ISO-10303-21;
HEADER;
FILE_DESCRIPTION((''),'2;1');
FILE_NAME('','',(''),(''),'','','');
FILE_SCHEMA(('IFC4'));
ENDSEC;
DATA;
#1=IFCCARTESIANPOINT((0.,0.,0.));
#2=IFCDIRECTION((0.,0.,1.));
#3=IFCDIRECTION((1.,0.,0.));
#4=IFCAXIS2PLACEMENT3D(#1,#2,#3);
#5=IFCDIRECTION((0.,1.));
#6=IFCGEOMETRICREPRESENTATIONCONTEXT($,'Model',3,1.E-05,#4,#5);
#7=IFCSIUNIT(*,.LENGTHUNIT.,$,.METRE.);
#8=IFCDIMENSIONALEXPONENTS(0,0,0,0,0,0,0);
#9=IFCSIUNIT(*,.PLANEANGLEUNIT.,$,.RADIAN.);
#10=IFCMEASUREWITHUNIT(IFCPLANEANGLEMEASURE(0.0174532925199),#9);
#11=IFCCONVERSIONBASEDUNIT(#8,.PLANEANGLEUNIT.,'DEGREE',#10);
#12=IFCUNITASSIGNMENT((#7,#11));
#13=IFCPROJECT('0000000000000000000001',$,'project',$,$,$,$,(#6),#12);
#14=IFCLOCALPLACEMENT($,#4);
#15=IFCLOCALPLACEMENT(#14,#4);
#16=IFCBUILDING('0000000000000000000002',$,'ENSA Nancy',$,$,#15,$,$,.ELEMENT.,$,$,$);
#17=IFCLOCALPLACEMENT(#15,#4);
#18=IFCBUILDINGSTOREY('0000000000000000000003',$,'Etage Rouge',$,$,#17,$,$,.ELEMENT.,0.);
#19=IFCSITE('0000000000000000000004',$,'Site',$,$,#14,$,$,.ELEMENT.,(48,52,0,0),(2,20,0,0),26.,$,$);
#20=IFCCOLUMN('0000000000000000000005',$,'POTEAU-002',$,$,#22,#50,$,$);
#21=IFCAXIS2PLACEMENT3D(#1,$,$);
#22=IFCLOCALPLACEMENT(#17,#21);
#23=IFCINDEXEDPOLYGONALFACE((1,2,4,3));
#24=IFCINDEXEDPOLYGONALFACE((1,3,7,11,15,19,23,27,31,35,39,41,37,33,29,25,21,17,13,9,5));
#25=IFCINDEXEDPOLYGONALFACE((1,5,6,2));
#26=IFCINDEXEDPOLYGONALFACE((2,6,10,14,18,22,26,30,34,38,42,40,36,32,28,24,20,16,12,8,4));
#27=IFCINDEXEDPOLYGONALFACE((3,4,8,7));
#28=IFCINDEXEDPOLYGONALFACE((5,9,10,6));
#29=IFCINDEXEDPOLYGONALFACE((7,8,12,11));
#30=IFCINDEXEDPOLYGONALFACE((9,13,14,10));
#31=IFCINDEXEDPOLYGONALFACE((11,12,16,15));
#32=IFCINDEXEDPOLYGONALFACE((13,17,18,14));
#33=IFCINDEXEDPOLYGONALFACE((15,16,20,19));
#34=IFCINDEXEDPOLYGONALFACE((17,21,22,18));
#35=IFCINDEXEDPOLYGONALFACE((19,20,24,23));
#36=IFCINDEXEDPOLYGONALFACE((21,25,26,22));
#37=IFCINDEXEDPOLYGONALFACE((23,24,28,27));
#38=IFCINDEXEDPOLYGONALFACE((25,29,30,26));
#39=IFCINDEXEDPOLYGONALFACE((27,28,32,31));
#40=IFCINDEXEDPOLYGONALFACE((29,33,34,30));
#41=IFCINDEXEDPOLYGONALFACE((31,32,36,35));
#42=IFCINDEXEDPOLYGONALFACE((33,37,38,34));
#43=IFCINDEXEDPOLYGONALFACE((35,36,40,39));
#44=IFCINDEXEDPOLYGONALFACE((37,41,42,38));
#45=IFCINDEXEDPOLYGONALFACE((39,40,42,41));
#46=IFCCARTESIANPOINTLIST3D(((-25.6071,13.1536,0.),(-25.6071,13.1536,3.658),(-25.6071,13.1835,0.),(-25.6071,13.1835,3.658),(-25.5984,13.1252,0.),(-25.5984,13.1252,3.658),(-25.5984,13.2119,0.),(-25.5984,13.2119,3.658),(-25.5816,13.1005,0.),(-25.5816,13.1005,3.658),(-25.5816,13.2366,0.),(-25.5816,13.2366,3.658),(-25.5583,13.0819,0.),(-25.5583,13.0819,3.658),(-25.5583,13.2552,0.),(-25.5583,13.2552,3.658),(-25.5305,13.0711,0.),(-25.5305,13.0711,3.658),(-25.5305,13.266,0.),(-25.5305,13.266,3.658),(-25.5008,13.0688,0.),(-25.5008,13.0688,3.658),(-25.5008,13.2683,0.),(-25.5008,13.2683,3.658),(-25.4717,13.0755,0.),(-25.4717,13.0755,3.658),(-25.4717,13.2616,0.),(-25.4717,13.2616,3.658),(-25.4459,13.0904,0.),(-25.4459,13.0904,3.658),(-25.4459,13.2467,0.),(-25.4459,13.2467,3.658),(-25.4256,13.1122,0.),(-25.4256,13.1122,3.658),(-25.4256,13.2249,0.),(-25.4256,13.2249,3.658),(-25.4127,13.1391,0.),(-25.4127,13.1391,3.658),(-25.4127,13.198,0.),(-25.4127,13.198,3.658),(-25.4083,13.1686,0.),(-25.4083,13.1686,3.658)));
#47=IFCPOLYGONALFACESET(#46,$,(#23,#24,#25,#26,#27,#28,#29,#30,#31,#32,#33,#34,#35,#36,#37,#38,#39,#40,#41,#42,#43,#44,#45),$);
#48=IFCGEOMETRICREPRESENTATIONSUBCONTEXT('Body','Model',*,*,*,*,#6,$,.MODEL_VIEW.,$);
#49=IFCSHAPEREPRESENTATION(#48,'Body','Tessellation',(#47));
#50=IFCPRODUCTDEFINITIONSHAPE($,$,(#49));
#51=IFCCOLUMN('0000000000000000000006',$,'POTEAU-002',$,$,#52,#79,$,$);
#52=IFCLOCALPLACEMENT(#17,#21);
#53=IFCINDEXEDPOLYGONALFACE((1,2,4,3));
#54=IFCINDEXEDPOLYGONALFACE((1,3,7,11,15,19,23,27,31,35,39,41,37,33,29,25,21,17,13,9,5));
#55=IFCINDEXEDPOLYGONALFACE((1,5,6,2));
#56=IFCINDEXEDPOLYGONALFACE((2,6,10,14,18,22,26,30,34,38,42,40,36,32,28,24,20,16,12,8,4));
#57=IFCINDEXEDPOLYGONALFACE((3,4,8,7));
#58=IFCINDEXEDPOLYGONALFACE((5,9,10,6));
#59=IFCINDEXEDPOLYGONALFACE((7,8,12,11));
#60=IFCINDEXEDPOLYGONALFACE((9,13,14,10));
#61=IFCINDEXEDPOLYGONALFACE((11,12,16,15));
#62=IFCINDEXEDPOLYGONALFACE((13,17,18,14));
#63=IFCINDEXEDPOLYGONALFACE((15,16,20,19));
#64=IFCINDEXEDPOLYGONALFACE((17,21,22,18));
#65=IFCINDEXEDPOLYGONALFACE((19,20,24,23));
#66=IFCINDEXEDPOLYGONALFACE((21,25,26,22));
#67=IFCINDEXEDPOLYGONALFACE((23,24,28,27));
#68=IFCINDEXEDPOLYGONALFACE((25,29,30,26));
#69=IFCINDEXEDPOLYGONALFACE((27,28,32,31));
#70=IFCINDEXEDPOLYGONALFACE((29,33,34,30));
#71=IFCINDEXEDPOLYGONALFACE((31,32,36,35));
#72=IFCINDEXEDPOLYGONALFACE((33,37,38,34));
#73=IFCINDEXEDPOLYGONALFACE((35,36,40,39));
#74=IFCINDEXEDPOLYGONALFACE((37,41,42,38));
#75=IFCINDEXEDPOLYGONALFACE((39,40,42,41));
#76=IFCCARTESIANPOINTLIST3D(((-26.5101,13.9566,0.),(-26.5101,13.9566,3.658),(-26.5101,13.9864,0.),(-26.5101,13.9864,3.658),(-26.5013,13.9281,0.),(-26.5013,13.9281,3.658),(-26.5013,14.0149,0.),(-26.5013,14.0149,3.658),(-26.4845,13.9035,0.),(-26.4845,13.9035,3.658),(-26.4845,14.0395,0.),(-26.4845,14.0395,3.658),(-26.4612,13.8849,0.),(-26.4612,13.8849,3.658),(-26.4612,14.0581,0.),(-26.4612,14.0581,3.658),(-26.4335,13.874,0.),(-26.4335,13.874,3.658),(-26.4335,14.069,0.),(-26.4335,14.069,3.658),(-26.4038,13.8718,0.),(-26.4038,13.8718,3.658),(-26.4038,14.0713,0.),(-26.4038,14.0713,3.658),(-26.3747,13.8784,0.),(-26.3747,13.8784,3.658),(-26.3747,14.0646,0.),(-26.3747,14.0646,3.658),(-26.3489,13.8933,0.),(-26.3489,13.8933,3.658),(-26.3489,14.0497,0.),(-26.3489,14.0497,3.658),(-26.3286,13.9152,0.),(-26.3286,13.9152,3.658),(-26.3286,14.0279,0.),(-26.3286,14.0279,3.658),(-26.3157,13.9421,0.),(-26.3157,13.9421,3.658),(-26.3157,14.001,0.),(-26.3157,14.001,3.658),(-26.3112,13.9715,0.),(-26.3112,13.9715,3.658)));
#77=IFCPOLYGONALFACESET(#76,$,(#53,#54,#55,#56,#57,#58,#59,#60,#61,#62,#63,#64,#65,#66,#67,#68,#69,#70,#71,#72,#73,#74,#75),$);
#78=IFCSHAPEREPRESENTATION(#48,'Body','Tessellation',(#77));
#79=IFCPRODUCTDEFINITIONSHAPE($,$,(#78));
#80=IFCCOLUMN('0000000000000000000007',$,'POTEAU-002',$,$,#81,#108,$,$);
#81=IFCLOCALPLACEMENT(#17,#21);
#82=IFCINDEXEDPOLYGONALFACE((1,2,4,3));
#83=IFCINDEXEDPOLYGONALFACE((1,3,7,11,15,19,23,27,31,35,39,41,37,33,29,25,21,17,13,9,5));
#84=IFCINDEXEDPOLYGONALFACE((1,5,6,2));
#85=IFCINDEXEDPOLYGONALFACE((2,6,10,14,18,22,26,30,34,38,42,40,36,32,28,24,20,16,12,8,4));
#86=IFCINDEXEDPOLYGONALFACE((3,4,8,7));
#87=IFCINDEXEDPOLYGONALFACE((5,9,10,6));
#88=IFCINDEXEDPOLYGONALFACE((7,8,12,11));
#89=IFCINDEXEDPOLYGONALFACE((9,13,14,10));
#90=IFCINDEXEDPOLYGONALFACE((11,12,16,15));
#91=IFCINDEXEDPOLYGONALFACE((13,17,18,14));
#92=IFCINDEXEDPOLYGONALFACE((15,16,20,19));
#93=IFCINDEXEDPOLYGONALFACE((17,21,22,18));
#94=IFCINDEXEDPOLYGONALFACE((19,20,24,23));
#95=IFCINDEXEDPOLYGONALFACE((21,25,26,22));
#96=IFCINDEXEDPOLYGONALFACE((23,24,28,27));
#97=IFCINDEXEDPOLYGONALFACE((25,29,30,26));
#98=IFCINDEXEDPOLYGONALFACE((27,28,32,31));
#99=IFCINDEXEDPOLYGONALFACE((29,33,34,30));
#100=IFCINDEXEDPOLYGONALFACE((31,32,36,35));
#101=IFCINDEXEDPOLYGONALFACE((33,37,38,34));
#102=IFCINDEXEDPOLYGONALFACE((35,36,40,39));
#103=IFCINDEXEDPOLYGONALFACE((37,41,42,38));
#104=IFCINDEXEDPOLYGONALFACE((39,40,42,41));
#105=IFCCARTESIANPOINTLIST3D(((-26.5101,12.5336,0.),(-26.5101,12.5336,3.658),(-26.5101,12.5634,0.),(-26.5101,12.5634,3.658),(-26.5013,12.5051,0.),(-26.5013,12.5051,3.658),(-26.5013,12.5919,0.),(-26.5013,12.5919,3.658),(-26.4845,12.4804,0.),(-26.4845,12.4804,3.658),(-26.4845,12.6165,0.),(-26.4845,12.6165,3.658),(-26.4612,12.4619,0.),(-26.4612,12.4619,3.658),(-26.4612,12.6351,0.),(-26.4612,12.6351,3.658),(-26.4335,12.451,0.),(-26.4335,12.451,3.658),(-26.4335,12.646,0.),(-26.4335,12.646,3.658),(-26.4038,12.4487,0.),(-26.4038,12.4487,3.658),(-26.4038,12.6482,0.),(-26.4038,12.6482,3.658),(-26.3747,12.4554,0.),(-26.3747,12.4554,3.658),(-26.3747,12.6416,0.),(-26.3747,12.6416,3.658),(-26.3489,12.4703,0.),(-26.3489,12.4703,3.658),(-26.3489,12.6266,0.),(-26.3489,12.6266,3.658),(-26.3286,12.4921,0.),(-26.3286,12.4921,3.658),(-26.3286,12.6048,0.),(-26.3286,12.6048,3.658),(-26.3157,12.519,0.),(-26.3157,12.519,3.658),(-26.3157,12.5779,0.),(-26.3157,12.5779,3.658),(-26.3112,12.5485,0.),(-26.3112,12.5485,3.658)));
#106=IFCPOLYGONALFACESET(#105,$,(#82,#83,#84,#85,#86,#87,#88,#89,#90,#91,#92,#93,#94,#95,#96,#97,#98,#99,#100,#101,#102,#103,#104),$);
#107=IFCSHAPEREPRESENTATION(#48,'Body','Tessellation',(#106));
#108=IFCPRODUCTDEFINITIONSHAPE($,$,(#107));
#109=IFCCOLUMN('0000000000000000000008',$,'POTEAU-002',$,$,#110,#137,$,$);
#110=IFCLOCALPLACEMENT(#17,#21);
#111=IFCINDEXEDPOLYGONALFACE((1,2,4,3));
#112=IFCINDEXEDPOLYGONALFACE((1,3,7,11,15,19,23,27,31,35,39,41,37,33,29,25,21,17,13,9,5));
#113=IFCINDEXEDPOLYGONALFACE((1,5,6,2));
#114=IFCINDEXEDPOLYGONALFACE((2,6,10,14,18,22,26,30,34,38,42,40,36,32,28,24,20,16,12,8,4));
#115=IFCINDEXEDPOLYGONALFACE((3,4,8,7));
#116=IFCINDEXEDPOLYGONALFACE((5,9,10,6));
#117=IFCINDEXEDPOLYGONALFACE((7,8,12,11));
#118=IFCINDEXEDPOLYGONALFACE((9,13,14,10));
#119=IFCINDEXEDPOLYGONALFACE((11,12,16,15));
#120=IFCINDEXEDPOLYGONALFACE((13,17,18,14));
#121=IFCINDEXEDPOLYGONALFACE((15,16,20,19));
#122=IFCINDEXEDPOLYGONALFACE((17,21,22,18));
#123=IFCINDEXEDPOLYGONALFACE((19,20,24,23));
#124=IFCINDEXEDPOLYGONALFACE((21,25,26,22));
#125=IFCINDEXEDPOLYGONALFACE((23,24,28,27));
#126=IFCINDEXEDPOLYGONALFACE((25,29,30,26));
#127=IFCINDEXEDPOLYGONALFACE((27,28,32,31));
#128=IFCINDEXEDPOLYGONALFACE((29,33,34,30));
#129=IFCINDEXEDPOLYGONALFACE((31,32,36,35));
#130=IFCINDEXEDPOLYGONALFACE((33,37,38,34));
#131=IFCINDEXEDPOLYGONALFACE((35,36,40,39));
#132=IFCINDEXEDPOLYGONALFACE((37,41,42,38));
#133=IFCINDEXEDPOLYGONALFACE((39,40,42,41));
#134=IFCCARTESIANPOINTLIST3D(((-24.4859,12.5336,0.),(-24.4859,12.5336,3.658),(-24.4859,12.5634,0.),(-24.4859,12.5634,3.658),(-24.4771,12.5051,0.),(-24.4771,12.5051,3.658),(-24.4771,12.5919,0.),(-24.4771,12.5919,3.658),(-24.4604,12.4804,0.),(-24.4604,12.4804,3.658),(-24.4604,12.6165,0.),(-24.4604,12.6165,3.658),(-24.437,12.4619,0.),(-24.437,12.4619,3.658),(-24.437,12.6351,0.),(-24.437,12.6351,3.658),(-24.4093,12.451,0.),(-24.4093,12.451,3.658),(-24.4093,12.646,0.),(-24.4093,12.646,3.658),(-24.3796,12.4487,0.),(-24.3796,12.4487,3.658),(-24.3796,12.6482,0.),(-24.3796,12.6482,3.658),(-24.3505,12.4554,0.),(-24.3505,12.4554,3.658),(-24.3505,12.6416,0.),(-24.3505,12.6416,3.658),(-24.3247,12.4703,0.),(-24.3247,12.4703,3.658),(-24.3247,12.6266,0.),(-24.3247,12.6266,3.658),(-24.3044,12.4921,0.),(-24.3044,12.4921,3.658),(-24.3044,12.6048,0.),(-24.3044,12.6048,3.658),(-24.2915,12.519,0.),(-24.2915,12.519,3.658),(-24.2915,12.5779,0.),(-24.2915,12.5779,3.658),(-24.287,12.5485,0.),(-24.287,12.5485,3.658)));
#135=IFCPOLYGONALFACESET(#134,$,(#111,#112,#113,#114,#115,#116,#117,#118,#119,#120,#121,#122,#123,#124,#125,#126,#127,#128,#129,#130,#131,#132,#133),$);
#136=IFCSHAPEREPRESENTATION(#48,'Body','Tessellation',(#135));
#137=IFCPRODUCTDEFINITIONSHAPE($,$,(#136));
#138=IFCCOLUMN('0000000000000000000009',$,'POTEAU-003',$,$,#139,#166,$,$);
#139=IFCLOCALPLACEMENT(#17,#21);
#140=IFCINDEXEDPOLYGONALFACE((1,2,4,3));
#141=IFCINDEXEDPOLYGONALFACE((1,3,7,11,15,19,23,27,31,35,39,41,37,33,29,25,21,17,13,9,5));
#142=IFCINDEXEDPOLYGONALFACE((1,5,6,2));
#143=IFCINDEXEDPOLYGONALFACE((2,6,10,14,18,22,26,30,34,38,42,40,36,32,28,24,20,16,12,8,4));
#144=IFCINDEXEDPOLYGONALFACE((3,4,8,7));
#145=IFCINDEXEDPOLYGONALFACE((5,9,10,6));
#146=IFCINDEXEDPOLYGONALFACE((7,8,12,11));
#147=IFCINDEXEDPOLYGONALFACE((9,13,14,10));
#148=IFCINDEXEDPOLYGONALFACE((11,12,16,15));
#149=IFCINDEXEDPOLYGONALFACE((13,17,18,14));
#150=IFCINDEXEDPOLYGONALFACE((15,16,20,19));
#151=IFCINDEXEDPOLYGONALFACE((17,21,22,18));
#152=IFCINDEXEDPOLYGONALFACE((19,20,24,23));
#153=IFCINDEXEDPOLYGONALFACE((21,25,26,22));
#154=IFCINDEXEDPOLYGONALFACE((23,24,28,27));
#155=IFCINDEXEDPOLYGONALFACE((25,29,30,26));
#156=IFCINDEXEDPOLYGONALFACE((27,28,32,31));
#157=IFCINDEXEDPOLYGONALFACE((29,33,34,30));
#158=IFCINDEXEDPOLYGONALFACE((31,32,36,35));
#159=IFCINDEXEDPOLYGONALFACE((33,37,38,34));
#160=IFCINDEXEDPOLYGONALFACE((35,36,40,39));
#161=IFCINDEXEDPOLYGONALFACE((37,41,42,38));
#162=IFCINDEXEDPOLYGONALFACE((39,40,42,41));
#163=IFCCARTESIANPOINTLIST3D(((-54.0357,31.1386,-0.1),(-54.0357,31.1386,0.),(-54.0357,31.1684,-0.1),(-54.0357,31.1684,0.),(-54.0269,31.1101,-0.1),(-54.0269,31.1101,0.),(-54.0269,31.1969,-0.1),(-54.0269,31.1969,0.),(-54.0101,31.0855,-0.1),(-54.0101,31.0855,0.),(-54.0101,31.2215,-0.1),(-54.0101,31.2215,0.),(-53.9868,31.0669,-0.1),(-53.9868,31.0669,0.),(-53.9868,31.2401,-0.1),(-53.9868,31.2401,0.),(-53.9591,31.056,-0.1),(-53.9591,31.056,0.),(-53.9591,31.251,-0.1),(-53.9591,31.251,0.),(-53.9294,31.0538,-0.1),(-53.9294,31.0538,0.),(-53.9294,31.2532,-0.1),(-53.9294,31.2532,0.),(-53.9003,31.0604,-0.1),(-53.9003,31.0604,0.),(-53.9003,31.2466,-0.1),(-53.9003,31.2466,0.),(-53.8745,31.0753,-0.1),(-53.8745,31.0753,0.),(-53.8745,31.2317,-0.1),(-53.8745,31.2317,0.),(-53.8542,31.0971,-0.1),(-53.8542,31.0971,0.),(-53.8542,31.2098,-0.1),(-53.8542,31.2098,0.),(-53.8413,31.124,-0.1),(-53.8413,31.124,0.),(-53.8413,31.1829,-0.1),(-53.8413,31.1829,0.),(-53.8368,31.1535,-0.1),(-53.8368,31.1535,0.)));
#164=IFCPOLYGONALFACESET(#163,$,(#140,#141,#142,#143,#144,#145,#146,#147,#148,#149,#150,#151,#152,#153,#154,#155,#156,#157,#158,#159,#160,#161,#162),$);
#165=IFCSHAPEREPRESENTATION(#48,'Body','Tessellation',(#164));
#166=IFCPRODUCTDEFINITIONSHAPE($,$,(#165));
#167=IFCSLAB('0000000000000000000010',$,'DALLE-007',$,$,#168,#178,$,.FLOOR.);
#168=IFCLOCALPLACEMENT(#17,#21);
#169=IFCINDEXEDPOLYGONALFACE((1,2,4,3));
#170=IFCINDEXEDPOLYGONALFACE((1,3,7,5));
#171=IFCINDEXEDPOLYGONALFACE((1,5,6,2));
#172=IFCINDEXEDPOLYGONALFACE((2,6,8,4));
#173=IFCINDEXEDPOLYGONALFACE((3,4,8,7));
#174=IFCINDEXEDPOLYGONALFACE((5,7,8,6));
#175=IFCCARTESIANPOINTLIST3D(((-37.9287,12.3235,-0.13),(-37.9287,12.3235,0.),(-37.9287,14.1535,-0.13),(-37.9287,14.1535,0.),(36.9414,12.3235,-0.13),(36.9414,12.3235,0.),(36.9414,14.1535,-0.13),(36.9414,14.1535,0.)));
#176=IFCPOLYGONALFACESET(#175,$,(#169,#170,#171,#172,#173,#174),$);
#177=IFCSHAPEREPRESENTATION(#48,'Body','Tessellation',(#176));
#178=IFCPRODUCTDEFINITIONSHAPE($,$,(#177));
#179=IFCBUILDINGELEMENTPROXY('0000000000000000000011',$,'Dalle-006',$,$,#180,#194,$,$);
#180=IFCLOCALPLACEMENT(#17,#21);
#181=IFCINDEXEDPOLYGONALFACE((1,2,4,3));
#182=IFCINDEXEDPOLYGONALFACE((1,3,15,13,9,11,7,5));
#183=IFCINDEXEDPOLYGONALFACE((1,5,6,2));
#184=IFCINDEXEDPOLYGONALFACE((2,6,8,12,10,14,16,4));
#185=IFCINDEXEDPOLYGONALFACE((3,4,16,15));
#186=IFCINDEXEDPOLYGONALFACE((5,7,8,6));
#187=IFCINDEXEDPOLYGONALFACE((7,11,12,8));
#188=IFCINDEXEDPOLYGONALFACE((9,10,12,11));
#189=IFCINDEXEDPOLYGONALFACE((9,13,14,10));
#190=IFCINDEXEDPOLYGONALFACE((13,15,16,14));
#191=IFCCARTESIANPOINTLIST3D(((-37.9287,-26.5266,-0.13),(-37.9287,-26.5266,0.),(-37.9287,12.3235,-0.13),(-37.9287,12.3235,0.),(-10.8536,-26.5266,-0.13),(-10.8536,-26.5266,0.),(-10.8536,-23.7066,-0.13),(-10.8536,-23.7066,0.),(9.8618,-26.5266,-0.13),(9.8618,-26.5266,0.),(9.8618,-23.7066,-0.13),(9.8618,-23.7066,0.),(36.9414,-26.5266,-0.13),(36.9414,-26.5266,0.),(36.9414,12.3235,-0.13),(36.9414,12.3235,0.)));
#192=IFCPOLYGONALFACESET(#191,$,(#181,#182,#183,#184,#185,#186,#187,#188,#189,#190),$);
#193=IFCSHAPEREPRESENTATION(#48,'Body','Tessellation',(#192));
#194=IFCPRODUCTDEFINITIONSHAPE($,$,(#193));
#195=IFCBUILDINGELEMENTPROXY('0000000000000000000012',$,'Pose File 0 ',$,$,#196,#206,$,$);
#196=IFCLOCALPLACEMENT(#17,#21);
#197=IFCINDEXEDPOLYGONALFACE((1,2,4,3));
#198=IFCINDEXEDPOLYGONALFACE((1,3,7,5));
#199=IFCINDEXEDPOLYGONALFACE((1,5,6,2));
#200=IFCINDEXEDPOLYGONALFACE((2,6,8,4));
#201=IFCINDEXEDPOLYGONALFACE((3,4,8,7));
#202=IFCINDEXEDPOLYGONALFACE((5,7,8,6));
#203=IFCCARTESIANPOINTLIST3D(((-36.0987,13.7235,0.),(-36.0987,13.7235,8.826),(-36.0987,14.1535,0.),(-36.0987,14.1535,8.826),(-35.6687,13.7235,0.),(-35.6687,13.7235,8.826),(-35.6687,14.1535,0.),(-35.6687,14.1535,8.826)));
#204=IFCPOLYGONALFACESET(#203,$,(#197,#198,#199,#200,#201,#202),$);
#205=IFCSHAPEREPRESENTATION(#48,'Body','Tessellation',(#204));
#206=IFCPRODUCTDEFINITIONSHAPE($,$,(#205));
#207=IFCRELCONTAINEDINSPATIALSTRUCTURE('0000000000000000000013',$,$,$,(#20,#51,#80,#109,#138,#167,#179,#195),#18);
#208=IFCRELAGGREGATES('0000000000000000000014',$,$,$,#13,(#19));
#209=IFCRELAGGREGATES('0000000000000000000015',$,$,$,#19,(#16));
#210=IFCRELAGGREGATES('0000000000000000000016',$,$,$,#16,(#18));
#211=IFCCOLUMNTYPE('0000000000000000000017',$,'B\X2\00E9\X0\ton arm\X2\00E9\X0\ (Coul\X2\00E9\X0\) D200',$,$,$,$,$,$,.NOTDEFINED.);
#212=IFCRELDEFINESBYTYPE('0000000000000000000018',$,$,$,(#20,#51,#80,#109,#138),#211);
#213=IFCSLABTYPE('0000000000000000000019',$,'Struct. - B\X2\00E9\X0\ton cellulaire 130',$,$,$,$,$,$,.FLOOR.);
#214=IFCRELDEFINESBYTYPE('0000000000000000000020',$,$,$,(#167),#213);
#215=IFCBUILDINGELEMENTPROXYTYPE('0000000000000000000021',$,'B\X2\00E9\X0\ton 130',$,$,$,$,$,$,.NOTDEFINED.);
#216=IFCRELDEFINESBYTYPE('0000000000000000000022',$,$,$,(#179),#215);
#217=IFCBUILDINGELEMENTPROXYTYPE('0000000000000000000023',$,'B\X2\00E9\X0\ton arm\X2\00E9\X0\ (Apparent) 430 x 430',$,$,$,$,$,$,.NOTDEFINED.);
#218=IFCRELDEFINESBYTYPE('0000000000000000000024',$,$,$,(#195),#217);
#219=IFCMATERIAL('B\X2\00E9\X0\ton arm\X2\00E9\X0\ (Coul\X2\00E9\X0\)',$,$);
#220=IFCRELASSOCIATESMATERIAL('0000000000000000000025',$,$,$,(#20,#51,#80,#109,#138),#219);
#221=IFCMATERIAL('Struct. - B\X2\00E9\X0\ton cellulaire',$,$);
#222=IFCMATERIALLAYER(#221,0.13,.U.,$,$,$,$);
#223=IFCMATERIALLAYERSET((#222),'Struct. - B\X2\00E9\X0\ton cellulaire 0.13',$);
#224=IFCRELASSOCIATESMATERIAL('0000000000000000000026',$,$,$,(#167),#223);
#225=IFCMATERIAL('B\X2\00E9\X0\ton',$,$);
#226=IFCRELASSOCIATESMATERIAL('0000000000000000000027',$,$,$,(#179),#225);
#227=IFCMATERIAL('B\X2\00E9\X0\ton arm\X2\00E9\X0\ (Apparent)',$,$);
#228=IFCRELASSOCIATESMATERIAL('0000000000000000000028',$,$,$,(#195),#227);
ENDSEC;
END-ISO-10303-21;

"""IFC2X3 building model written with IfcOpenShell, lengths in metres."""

from ifc_helpers import new_model, entity, si_unit, converted_unit, direction, frame, origin_with_axes, origin_2d_with_axis, place, context, subcontext, project, spatial, polyline, rectangle, circle, outline, extrude, material, layer, layer_set, layer_usage, type_object, element, save


model = new_model("IFC2X3")

# Units and contexts
model_context = context("Model", 3, precision=1e-05, world=origin_with_axes(), true_north=direction((0.0, 1.0)))
body_context = subcontext(model_context, "Body", "Model", "MODEL_VIEW")
ifc_project = project(units=[si_unit("LENGTHUNIT", "METRE"), converted_unit("PLANEANGLEUNIT", "DEGREE", entity("IfcPlaneAngleMeasure", 0.0174532925199), si_unit("PLANEANGLEUNIT", "RADIAN"), dimensions=[0, 0, 0, 0, 0, 0, 0])], contexts=[model_context])

# Site, building, storey
site_placement = place(None, origin_with_axes())
site = spatial("IfcSite", under=ifc_project, at=site_placement, Name="Site", CompositionType="ELEMENT", RefLatitude=(48, 52, 0, 0), RefLongitude=(2, 20, 0, 0), RefElevation=26.0)
building_placement = place(site_placement, origin_with_axes())
building = spatial("IfcBuilding", under=site, at=building_placement, Name="ENSA Nancy", CompositionType="ELEMENT")
storey_placement = place(building_placement, origin_with_axes())
storey = spatial("IfcBuildingStorey", under=building, at=storey_placement, Name="Etage Rouge", CompositionType="ELEMENT", Elevation=0.0)

# Columns
ifc_material_1 = material(Name="Béton armé (Coulé)")
column_type = type_object("IfcColumnType", Name="Béton armé (Coulé) D200", PredefinedType="NOTDEFINED")
for number, where, z_axis, x_axis, name in (
    (1, (-25.5083, 13.1686, 0.0), (0.0, 0.0, 1.0), (1.0, 0.0, 0.0), "POTEAU-002"),
    (2, (-26.4112, 13.9715, 0.0), (0.0, 0.0, 1.0), (1.0, 0.0, 0.0), "POTEAU-002"),
    (3, (-26.4112, 12.5485, 0.0), (0.0, 0.0, 1.0), (1.0, 0.0, 0.0), "POTEAU-002"),
    (4, (-24.387, 12.5485, 0.0), (0.0, 0.0, 1.0), (1.0, 0.0, 0.0), "POTEAU-002"),
):
    element("IfcColumn", number, at=place(storey_placement, frame(where, z_axis=z_axis, x_axis=x_axis)), inside=storey, type_object=column_type, material=ifc_material_1, Name=name, context=body_context, shape_type="SweptSolid", body=[
        extrude(circle(Radius=0.1, at=origin_2d_with_axis()), origin_with_axes(), (0.0, 0.0, 1.0), 3.658),
    ])
column_placement = place(storey_placement, frame((-53.9368, 31.1535, -0.1), z_axis=(0.0, 0.0, 1.0), x_axis=(1.0, 0.0, 0.0)))
element("IfcColumn", 5, at=column_placement, inside=storey, type_object=column_type, material=ifc_material_1, Name="POTEAU-003", context=body_context, shape_type="SweptSolid", body=[
    extrude(circle(Radius=0.1, at=origin_2d_with_axis()), origin_with_axes(), (0.0, 0.0, 1.0), 0.1),
])

# Slab
ifc_material_2 = material(Name="Struct. - Béton cellulaire")
ifc_layer = layer(ifc_material_2, 0.13, ventilated="UNKNOWN")
ifc_layer_set = layer_set([ifc_layer], Name="Struct. - Béton cellulaire 0.13")
ifc_layer_usage = layer_usage(ifc_layer_set, "AXIS3", "NEGATIVE", 0.13)
slab_type = type_object("IfcSlabType", Name="Struct. - Béton cellulaire 130", PredefinedType="FLOOR")
slab_placement = place(storey_placement, frame((-37.9287, 12.3235, 0.0), z_axis=(0.0, 0.0, 1.0), x_axis=(1.0, 0.0, 0.0)))
element("IfcSlab", 6, at=slab_placement, inside=storey, type_object=slab_type, material=ifc_layer_usage, Name="DALLE-007", PredefinedType="FLOOR", context=body_context, shape_type="SweptSolid", body=[
    extrude(outline(polyline([(0.0, 0.0), (74.8701, 0.0), (74.8701, 1.83), (0.0, 1.83), (0.0, 0.0)])), frame((0.0, 0.0, -0.13), z_axis=(0.0, 0.0, 1.0), x_axis=(1.0, 0.0, 0.0)), (0.0, 0.0, 1.0), 0.13),
])

# Building element proxies
ifc_material_3 = material(Name="Béton")
building_element_proxy_type_1 = type_object("IfcBuildingElementProxyType", Name="Béton 130", PredefinedType="NOTDEFINED")
proxy_1_placement = place(storey_placement, frame((-37.9287, 12.3235, 0.0), z_axis=(0.0, 0.0, 1.0), x_axis=(1.0, 0.0, 0.0)))
element("IfcBuildingElementProxy", 7, at=proxy_1_placement, inside=storey, type_object=building_element_proxy_type_1, material=ifc_material_3, Name="Dalle-006", context=body_context, shape_type="SweptSolid", body=[
    extrude(outline(polyline([(0.0, 0.0), (0.0, -38.85), (27.0751, -38.85), (27.0751, -36.03), (47.7905, -36.03), (47.7905, -38.85), (74.8701, -38.85), (74.8701, 0.0), (0.0, 0.0)])), frame((0.0, 0.0, -0.13), z_axis=(0.0, 0.0, 1.0), x_axis=(1.0, 0.0, 0.0)), (0.0, 0.0, 1.0), 0.13),
])
ifc_material_4 = material(Name="Béton armé (Apparent)")
building_element_proxy_type_2 = type_object("IfcBuildingElementProxyType", Name="Béton armé (Apparent) 430 x 430", PredefinedType="NOTDEFINED")
proxy_2_placement = place(storey_placement, frame((-35.8837, 13.9385, 0.0), z_axis=(0.0, 0.0, 1.0), x_axis=(1.0, 0.0, 0.0)))
element("IfcBuildingElementProxy", 8, at=proxy_2_placement, inside=storey, type_object=building_element_proxy_type_2, material=ifc_material_4, Name="Pose File 0 ", context=body_context, shape_type="SweptSolid", body=[
    extrude(rectangle(XDim=0.43, YDim=0.43, at=origin_2d_with_axis()), frame((0.0, 0.0, 0.0), z_axis=(0.0, 0.0, -1.0), x_axis=(-1.0, 0.0, 0.0)), (0.0, 0.0, -1.0), 8.826),
])

save(model, "model.ifc")
